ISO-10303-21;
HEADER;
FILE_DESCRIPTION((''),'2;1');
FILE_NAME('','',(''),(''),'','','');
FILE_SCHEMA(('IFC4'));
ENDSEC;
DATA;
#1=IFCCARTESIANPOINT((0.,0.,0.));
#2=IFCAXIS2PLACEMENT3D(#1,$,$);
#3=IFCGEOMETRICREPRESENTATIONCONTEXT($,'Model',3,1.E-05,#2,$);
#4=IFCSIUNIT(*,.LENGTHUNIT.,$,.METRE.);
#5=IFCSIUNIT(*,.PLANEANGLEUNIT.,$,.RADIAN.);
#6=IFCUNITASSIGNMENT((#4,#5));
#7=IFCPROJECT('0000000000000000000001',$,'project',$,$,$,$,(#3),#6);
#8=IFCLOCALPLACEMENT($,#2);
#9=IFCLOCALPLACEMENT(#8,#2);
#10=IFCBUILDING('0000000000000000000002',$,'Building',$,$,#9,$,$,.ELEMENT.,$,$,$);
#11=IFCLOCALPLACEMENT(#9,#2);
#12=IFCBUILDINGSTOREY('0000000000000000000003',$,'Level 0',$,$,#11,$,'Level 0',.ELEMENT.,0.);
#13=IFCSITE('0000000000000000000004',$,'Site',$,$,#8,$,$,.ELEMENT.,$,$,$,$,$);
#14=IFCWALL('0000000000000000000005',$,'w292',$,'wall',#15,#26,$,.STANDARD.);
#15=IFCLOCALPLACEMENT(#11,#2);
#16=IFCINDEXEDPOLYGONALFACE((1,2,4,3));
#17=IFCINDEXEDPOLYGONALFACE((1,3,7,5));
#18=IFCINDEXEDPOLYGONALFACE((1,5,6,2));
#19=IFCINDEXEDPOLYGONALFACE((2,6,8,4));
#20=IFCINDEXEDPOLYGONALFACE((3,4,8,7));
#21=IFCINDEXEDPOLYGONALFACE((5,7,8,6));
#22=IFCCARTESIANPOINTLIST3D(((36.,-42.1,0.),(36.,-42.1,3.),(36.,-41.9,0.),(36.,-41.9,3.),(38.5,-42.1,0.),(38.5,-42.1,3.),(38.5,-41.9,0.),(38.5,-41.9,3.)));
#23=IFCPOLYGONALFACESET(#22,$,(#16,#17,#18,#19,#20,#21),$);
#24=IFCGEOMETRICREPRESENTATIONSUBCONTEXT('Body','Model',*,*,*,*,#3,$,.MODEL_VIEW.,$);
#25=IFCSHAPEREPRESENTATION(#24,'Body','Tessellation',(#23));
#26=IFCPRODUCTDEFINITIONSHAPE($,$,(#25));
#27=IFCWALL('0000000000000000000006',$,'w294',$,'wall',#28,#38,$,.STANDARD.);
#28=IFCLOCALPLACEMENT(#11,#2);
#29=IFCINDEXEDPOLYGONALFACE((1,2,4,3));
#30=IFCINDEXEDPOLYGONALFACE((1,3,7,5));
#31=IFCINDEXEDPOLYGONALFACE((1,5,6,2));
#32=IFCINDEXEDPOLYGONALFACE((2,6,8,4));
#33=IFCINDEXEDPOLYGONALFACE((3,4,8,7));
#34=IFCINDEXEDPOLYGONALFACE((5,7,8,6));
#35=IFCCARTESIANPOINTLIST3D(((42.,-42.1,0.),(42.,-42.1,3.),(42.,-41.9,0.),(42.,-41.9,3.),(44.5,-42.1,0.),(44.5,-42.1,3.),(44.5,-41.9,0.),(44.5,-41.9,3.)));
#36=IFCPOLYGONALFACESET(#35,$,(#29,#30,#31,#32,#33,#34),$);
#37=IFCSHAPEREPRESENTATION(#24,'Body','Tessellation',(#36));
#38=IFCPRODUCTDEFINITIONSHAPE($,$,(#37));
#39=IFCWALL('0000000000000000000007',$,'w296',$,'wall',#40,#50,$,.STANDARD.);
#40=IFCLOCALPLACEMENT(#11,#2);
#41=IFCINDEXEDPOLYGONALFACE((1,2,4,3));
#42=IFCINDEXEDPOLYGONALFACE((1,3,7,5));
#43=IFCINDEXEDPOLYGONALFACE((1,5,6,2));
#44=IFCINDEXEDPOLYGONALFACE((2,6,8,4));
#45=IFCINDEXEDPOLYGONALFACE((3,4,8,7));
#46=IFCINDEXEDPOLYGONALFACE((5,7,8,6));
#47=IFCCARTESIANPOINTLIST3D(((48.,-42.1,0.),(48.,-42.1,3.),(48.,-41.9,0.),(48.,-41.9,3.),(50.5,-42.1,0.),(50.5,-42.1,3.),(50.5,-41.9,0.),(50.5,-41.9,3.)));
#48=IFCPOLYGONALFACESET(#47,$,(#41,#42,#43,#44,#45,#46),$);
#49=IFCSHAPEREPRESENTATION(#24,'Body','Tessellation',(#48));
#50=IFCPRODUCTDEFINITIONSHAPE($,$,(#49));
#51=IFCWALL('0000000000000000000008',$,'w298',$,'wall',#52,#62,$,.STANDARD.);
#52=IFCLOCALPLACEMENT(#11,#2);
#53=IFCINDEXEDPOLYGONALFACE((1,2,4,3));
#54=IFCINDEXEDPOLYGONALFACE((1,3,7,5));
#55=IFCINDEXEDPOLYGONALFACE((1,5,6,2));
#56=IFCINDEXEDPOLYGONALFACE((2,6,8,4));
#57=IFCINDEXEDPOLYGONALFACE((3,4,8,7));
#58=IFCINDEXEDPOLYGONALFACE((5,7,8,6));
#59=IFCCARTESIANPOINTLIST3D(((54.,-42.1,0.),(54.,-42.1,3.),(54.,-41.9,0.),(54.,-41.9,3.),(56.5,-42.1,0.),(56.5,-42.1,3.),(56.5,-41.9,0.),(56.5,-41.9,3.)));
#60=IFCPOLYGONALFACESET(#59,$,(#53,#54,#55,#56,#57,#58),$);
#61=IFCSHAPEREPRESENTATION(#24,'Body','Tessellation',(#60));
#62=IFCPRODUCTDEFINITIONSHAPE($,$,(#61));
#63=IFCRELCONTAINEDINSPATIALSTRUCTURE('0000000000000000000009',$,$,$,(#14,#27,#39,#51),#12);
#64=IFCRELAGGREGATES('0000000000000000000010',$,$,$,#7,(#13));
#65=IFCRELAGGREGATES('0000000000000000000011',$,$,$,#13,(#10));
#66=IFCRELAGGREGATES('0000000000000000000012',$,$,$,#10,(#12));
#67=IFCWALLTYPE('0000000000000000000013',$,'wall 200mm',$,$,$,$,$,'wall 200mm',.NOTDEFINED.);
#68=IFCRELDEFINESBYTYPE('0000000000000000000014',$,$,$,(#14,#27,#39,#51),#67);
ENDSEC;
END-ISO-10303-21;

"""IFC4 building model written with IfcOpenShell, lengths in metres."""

from ifc_helpers import new_model, si_unit, frame, frame_2d, origin, place, context, subcontext, project, spatial, rectangle, extrude, type_object, element, save


model = new_model("IFC4")

# Units and contexts
model_context = context("Model", 3, precision=1e-05, world=origin())
body_context = subcontext(model_context, "Body", "Model", "MODEL_VIEW")
ifc_project = project(units=[si_unit("LENGTHUNIT", "METRE"), si_unit("PLANEANGLEUNIT", "RADIAN")], contexts=[model_context])

# Site, building, storey
site_placement = place(None, origin())
site = spatial("IfcSite", under=ifc_project, at=site_placement, Name="Site", CompositionType="ELEMENT")
building_placement = place(site_placement, origin())
building = spatial("IfcBuilding", under=site, at=building_placement, Name="Building", CompositionType="ELEMENT")
storey_placement = place(building_placement, origin())
storey = spatial("IfcBuildingStorey", under=building, at=storey_placement, Name="Level 0", LongName="Level 0", CompositionType="ELEMENT", Elevation=0.0)

# Walls
wall_type = type_object("IfcWallType", Name="wall 200mm", ElementType="wall 200mm", PredefinedType="NOTDEFINED")
for number, where, z_axis, x_axis, name in (
    (1, (36.0, -42.0, 0.0), (0.0, 0.0, 1.0), (1.0, 0.0, 0.0), "w292"),
    (2, (42.0, -42.0, 0.0), (0.0, 0.0, 1.0), (1.0, 0.0, 0.0), "w294"),
    (3, (48.0, -42.0, 0.0), (0.0, 0.0, 1.0), (1.0, 0.0, 0.0), "w296"),
    (4, (54.0, -42.0, 0.0), (0.0, 0.0, 1.0), (1.0, 0.0, 0.0), "w298"),
):
    element("IfcWall", number, at=place(storey_placement, frame(where, z_axis=z_axis, x_axis=x_axis)), inside=storey, type_object=wall_type, Name=name, ObjectType="wall", PredefinedType="STANDARD", context=body_context, shape_type="SweptSolid", body=[
        extrude(rectangle(XDim=2.5, YDim=0.2, at=frame_2d((1.25, 0.0))), origin(), (0.0, 0.0, 1.0), 3.0),
    ])

save(model, "model.ifc")
